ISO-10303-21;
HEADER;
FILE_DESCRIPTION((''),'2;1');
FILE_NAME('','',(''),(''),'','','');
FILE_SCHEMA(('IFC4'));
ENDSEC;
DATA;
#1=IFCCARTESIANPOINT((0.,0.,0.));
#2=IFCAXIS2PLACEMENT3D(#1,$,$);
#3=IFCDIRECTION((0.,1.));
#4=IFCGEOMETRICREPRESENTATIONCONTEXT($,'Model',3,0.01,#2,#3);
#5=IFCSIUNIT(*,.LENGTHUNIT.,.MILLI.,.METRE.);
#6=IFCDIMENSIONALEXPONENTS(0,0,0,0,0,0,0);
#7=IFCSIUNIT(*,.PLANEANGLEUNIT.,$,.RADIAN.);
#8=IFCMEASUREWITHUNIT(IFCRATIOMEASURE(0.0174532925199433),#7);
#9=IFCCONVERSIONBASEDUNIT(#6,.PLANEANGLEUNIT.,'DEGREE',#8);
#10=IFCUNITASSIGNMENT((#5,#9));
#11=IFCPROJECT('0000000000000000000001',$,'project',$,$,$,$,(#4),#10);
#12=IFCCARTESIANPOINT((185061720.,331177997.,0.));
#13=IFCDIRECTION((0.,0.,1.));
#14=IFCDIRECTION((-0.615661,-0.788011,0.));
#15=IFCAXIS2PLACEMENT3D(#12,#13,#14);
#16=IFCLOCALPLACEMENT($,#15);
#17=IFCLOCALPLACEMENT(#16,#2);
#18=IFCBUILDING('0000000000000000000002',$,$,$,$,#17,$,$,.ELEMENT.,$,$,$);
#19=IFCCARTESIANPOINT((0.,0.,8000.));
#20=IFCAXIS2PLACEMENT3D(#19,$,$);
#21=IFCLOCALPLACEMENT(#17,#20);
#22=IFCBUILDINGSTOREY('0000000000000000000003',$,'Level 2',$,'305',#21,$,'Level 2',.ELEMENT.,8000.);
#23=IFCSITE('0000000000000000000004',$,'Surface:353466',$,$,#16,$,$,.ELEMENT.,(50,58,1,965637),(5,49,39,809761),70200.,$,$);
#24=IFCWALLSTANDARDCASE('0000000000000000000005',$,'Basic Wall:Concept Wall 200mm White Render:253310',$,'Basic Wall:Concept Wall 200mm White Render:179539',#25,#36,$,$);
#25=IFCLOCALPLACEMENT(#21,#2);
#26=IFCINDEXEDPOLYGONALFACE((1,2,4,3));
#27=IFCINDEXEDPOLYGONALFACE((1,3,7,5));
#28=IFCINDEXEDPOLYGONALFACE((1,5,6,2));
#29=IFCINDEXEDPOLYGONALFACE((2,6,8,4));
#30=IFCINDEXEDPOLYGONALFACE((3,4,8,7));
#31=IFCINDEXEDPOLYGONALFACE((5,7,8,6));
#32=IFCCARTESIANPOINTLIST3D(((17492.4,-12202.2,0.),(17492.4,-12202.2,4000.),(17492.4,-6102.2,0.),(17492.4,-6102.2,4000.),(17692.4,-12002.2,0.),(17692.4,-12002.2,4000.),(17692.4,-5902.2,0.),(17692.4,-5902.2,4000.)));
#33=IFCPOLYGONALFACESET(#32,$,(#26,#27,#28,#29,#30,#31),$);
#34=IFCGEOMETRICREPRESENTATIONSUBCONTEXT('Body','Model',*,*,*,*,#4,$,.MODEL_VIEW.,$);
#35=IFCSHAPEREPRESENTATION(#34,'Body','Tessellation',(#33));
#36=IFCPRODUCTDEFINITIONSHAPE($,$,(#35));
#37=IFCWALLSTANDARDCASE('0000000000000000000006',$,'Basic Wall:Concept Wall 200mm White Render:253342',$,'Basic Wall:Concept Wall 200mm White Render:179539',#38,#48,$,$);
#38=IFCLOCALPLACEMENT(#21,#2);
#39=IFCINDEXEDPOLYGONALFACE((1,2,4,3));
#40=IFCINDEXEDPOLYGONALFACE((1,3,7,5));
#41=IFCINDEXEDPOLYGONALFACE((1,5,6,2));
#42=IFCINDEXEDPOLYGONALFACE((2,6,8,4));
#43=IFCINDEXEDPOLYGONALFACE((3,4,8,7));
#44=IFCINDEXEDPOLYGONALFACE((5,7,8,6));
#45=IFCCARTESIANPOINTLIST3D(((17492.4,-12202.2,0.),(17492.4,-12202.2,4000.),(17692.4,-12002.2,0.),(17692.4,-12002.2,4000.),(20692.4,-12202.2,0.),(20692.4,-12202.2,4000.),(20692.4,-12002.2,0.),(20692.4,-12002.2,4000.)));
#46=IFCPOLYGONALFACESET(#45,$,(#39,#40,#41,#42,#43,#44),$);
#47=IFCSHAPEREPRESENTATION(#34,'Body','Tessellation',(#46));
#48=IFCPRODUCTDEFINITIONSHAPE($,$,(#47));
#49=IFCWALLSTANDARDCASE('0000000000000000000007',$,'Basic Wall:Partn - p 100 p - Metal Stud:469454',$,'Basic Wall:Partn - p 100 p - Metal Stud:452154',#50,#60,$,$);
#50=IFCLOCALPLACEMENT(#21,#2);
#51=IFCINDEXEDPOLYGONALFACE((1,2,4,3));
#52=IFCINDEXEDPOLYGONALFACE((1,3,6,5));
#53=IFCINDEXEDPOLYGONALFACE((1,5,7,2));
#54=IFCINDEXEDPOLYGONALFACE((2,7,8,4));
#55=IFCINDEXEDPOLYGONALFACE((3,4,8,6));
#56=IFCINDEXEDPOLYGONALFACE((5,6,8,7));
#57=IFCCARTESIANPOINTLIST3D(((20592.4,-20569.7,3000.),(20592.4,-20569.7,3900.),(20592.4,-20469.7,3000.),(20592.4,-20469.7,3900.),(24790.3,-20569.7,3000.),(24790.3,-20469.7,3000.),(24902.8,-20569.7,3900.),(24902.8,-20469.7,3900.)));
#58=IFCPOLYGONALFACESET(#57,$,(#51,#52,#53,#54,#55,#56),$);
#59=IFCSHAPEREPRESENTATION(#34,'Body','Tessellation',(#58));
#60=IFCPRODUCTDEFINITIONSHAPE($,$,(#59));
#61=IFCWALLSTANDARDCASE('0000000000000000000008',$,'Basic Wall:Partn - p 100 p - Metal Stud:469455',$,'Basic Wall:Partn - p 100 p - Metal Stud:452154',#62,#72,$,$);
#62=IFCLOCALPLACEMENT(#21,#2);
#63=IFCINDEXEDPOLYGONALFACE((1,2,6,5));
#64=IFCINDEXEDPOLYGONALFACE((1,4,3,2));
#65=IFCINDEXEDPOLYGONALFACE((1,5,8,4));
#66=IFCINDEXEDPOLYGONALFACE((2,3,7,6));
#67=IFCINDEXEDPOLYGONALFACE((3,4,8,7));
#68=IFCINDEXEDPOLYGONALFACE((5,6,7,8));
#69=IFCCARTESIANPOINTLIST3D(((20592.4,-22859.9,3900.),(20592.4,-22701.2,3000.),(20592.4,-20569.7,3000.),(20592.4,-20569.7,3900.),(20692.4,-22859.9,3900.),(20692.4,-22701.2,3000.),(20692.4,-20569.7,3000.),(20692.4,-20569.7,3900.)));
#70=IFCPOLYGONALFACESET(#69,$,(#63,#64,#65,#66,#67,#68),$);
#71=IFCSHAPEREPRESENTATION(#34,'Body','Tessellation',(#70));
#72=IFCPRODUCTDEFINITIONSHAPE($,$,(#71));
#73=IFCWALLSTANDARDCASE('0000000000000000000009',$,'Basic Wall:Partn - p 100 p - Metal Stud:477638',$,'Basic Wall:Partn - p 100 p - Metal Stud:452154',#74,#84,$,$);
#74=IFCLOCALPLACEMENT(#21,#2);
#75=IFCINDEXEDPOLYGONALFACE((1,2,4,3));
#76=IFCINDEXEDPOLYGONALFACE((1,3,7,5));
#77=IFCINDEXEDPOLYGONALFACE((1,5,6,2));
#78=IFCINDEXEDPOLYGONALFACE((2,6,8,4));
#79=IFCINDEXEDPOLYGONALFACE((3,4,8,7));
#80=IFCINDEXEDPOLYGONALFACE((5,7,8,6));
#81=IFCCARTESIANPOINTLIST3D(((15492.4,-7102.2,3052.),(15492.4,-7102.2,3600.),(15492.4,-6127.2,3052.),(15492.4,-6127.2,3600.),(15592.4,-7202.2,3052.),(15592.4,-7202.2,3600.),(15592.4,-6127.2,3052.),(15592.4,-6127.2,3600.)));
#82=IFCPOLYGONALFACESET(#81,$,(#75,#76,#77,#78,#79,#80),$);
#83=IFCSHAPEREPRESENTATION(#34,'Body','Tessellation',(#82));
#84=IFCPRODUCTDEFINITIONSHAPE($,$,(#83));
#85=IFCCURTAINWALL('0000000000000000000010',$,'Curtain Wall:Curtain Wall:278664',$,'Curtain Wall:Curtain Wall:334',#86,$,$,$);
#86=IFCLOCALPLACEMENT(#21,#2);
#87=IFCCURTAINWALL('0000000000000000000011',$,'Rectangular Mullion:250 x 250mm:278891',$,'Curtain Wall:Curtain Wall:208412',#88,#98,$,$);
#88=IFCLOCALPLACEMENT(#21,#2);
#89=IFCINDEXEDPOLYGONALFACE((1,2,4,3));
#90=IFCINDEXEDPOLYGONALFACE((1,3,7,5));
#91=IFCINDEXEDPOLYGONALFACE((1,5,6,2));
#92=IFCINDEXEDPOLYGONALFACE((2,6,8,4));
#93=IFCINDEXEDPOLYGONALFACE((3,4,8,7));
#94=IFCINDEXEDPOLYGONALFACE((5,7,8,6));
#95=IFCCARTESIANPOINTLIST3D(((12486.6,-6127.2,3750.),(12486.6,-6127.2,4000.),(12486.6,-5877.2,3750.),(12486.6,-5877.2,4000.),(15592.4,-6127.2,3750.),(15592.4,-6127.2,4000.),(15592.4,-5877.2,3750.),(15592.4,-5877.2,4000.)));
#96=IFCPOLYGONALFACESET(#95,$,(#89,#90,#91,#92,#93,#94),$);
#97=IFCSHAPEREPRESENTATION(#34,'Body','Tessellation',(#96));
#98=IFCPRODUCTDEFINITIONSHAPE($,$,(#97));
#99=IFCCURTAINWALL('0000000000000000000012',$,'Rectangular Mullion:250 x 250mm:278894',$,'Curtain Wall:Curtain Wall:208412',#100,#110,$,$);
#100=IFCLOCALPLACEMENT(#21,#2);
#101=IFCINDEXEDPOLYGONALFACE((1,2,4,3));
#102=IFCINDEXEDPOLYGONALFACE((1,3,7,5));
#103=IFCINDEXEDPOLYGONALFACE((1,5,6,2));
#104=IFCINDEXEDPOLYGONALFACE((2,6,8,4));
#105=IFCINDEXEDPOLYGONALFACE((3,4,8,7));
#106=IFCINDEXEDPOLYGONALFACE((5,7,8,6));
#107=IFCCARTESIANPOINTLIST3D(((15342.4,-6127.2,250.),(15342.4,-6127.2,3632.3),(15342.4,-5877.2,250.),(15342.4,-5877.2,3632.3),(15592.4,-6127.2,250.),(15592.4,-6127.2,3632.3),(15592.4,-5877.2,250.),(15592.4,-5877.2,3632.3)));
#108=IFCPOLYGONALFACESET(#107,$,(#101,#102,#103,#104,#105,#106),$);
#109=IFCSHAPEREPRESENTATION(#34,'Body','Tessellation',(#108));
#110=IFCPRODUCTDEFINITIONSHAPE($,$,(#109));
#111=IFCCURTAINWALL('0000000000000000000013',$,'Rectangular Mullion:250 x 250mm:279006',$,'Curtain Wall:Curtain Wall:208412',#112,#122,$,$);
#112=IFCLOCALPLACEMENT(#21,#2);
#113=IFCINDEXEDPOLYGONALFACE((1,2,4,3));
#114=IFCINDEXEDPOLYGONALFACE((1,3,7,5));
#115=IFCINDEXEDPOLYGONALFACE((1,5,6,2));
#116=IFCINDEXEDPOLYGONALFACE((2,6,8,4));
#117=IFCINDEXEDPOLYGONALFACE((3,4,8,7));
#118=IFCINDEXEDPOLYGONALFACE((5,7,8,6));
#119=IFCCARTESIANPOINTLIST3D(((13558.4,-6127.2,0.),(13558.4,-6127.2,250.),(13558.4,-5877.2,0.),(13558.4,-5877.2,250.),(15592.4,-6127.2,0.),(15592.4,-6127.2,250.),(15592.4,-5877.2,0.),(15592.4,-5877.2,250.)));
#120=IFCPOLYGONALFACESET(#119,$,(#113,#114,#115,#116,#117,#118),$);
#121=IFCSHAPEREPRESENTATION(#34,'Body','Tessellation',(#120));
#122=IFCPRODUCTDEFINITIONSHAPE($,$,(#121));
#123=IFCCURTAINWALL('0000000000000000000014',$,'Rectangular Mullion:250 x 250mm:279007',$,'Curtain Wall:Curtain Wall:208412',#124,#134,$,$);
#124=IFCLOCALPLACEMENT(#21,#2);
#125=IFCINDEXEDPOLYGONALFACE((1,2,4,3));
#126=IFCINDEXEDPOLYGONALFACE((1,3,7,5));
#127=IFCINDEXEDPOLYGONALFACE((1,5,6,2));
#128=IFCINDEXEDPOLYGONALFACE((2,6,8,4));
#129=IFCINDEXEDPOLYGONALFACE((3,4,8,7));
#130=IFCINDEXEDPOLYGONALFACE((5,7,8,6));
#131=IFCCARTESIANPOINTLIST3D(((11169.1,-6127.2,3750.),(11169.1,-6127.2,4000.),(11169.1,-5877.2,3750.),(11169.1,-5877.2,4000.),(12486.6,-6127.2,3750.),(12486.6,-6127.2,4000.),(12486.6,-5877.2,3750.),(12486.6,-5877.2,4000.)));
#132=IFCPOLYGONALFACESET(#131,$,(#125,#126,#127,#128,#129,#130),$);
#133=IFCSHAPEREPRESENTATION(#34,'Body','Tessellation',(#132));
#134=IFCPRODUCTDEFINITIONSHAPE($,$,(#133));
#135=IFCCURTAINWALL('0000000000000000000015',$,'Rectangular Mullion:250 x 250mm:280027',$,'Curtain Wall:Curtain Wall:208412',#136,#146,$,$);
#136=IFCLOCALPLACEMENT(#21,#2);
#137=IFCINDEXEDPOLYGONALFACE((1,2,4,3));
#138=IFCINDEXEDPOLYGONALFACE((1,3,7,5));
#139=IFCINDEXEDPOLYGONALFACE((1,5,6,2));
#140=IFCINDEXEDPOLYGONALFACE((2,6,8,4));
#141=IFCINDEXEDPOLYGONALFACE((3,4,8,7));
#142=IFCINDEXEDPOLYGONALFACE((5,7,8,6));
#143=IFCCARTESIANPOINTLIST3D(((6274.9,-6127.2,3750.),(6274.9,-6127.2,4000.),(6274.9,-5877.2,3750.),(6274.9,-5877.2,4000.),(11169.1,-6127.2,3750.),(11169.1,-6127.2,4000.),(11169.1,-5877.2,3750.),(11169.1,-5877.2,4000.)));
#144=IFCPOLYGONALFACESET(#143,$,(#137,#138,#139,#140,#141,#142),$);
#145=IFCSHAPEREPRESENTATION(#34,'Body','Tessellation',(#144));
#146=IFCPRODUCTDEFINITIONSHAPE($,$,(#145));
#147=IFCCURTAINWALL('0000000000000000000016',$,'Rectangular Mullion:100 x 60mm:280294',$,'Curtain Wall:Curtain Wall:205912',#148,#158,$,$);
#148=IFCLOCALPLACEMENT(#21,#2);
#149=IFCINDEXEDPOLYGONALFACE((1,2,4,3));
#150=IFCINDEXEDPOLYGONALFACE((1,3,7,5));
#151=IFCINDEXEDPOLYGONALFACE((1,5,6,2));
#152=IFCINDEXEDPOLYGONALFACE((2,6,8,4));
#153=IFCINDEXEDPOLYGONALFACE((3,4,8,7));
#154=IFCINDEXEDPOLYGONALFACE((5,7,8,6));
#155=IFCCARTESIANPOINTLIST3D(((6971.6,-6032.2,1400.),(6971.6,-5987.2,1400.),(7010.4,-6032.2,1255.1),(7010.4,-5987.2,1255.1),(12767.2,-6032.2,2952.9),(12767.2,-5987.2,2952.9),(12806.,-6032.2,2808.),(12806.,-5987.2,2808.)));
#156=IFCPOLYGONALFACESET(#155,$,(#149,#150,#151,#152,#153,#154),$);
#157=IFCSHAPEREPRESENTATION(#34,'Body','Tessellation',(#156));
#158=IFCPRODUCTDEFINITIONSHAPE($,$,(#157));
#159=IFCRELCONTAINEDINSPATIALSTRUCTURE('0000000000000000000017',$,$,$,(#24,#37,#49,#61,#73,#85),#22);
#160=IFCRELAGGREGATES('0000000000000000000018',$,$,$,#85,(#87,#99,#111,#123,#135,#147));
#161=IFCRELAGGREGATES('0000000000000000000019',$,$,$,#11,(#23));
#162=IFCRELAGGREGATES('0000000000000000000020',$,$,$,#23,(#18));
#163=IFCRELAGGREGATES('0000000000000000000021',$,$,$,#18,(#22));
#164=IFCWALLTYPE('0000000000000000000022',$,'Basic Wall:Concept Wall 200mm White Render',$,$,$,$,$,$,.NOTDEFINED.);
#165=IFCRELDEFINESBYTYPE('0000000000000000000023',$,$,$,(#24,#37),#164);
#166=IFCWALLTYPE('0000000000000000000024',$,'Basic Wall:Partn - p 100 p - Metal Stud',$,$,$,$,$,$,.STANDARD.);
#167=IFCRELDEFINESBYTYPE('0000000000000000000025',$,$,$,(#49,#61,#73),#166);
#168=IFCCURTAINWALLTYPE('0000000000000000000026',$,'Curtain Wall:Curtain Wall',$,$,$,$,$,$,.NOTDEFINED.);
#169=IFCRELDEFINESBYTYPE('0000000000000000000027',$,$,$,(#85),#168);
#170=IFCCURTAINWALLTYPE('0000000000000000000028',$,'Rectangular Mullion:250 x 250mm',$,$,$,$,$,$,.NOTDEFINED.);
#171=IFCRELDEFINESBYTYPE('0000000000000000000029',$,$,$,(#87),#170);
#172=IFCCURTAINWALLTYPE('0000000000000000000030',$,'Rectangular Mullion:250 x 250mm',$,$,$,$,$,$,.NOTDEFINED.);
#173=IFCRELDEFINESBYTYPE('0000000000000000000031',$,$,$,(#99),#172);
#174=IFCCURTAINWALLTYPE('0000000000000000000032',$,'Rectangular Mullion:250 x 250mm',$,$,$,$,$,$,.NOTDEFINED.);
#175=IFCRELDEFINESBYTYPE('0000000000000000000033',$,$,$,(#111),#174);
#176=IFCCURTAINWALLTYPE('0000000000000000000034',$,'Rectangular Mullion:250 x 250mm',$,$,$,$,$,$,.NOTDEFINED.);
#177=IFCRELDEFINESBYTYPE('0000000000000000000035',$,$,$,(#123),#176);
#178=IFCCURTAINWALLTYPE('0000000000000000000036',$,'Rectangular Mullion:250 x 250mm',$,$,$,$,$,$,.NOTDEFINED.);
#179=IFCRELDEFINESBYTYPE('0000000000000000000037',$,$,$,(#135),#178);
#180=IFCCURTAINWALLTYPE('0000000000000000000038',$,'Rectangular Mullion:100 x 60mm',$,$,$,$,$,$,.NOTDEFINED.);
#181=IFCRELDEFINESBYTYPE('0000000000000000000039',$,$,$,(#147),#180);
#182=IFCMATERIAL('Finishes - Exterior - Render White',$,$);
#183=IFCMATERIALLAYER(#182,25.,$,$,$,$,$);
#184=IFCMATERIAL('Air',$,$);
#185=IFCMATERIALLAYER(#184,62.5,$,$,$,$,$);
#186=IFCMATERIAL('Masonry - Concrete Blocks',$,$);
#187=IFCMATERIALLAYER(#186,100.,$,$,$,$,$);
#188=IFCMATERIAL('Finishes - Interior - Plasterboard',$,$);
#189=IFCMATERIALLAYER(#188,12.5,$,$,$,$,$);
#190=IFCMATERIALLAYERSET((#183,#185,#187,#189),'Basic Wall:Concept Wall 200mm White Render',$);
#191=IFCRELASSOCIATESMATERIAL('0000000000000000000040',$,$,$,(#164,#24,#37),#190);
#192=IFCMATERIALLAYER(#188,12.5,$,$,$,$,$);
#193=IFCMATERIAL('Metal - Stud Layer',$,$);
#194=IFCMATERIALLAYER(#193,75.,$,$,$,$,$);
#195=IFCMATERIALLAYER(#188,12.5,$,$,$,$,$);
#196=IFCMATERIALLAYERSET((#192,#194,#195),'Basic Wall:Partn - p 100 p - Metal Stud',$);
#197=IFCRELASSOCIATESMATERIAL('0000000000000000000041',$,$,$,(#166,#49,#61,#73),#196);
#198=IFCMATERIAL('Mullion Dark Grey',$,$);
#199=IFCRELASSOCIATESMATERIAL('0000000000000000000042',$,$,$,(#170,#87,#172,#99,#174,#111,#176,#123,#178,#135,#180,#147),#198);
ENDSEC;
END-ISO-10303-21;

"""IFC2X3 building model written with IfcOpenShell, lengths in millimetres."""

from ifc_helpers import new_model, entity, si_unit, converted_unit, direction, frame, frame_2d, origin, origin_2d_with_axis, place, context, subcontext, project, spatial, polyline, rectangle, outline, extrude, clip, halfspace, source, transform, mapped, material, layer, layer_set, layer_usage, type_object, type_shapes, element, aggregate, save


model = new_model("IFC2X3")

# Units and contexts
model_context = context("Model", 3, precision=0.01, world=origin(), true_north=direction((0.0, 1.0)))
body_context = subcontext(model_context, "Body", "Model", "MODEL_VIEW")
ifc_project = project(units=[si_unit("LENGTHUNIT", "METRE", prefix="MILLI"), converted_unit("PLANEANGLEUNIT", "DEGREE", entity("IfcRatioMeasure", 0.0174532925199433), si_unit("PLANEANGLEUNIT", "RADIAN"), dimensions=[0, 0, 0, 0, 0, 0, 0])], contexts=[model_context])

# Site, building, storey
site_placement = place(None, frame((185061720.0, 331177997.0, 0.0), z_axis=(0.0, 0.0, 1.0), x_axis=(-0.615661, -0.788011, 0.0)))
site = spatial("IfcSite", under=ifc_project, at=site_placement, Name="Surface:353466", CompositionType="ELEMENT", RefLatitude=(50, 58, 1, 965637), RefLongitude=(5, 49, 39, 809761), RefElevation=70200.0)
building_placement = place(site_placement, origin())
building = spatial("IfcBuilding", under=site, at=building_placement, CompositionType="ELEMENT")
storey_placement = place(building_placement, frame((0.0, 0.0, 8000.0)))
storey = spatial("IfcBuildingStorey", under=building, at=storey_placement, Name="Level 2", ObjectType="305", LongName="Level 2", CompositionType="ELEMENT", Elevation=8000.0)

# Walls
ifc_material_1 = material(Name="Finishes - Exterior - Render White")
ifc_layer_1 = layer(ifc_material_1, 25.0)
ifc_material_2 = material(Name="Air")
ifc_layer_2 = layer(ifc_material_2, 62.5)
ifc_material_3 = material(Name="Masonry - Concrete Blocks")
ifc_layer_3 = layer(ifc_material_3, 100.0)
ifc_material_4 = material(Name="Finishes - Interior - Plasterboard")
ifc_layer_4 = layer(ifc_material_4, 12.5)
ifc_layer_set_1 = layer_set([ifc_layer_1, ifc_layer_2, ifc_layer_3, ifc_layer_4], Name="Basic Wall:Concept Wall 200mm White Render")
ifc_layer_usage_1 = layer_usage(ifc_layer_set_1, "AXIS2", "NEGATIVE", 100.0)
wall_type_1 = type_object("IfcWallType", Name="Basic Wall:Concept Wall 200mm White Render", PredefinedType="NOTDEFINED", material=ifc_layer_set_1)
wall_1_placement = place(storey_placement, frame((17592.4, -5902.2, 0.0), z_axis=(0.0, 0.0, 1.0), x_axis=(0.0, -1.0, 0.0)))
element("IfcWallStandardCase", 1, at=wall_1_placement, inside=storey, type_object=wall_type_1, material=ifc_layer_usage_1, Name="Basic Wall:Concept Wall 200mm White Render:253310", ObjectType="Basic Wall:Concept Wall 200mm White Render:179539", context=body_context, shape_type="Clipping", body=[
    clip(extrude(outline(polyline([(6300.0, -100.0), (6100.0, 100.0), (0.0, 100.0), (200.0, -100.0), (6300.0, -100.0)])), origin(), (0.0, 0.0, 1.0), 4000.0), halfspace(frame((0.0, 0.0, -8000.0)), True)),
])
ifc_layer_usage_2 = layer_usage(ifc_layer_set_1, "AXIS2", "NEGATIVE", 100.0)
wall_2_placement = place(storey_placement, frame((17492.4, -12102.2, 0.0)))
element("IfcWallStandardCase", 2, at=wall_2_placement, inside=storey, type_object=wall_type_1, material=ifc_layer_usage_2, Name="Basic Wall:Concept Wall 200mm White Render:253342", ObjectType="Basic Wall:Concept Wall 200mm White Render:179539", context=body_context, shape_type="Clipping", body=[
    clip(extrude(outline(polyline([(0.0, -100.0), (3200.0, -100.0), (3200.0, 100.0), (200.0, 100.0), (0.0, -100.0)])), origin(), (0.0, 0.0, 1.0), 4000.0), halfspace(frame((0.0, 0.0, -8000.0)), True)),
])
ifc_layer_5 = layer(ifc_material_4, 12.5)
ifc_material_5 = material(Name="Metal - Stud Layer")
ifc_layer_6 = layer(ifc_material_5, 75.0)
ifc_layer_7 = layer(ifc_material_4, 12.5)
ifc_layer_set_2 = layer_set([ifc_layer_5, ifc_layer_6, ifc_layer_7], Name="Basic Wall:Partn - p 100 p - Metal Stud")
ifc_layer_usage_3 = layer_usage(ifc_layer_set_2, "AXIS2", "POSITIVE", -50.0)
wall_type_2 = type_object("IfcWallType", Name="Basic Wall:Partn - p 100 p - Metal Stud", PredefinedType="STANDARD", material=ifc_layer_set_2)
wall_3_placement = place(storey_placement, frame((24902.8, -20519.7, 3000.0), z_axis=(0.0, 0.0, 1.0), x_axis=(-1.0, 0.0, 0.0)))
element("IfcWallStandardCase", 3, at=wall_3_placement, inside=storey, type_object=wall_type_2, material=ifc_layer_usage_3, Name="Basic Wall:Partn - p 100 p - Metal Stud:469454", ObjectType="Basic Wall:Partn - p 100 p - Metal Stud:452154", context=body_context, shape_type="Clipping", body=[
    clip(extrude(rectangle(XDim=4310.4, YDim=100.0, at=frame_2d((2155.2, 0.0), x_axis=(-1.0, 0.0))), origin(), (0.0, 0.0, 1.0), 900.0), halfspace(frame((112.5, -50.0, 0.0), z_axis=(-0.992278, 0.0, -0.124035), x_axis=(0.0, 1.0, 0.0)), False)),
])
ifc_layer_usage_4 = layer_usage(ifc_layer_set_2, "AXIS2", "POSITIVE", -50.0)
wall_4_placement = place(storey_placement, frame((20642.4, -20569.7, 3000.0), z_axis=(0.0, 0.0, 1.0), x_axis=(0.0, -1.0, 0.0)))
element("IfcWallStandardCase", 4, at=wall_4_placement, inside=storey, type_object=wall_type_2, material=ifc_layer_usage_4, Name="Basic Wall:Partn - p 100 p - Metal Stud:469455", ObjectType="Basic Wall:Partn - p 100 p - Metal Stud:452154", context=body_context, shape_type="Clipping", body=[
    clip(extrude(rectangle(XDim=2290.2, YDim=100.0, at=frame_2d((1145.1, 0.0), x_axis=(-1.0, 0.0))), origin(), (0.0, 0.0, 1.0), 900.0), halfspace(frame((2290.2, -50.0, 900.0), z_axis=(0.984808, 0.0, -0.173648), x_axis=(0.0, 1.0, 0.0)), False)),
])
ifc_layer_usage_5 = layer_usage(ifc_layer_set_2, "AXIS2", "POSITIVE", -50.0)
wall_5_placement = place(storey_placement, frame((15542.4, -6127.2, 3052.0), z_axis=(0.0, 0.0, 1.0), x_axis=(0.0, -1.0, 0.0)))
element("IfcWallStandardCase", 5, at=wall_5_placement, inside=storey, type_object=wall_type_2, material=ifc_layer_usage_5, Name="Basic Wall:Partn - p 100 p - Metal Stud:477638", ObjectType="Basic Wall:Partn - p 100 p - Metal Stud:452154", context=body_context, shape_type="SweptSolid", body=[
    extrude(outline(polyline([(975.0, -50.0), (1075.0, 50.0), (0.0, 50.0), (0.0, -50.0), (975.0, -50.0)])), origin(), (0.0, 0.0, 1.0), 548.0),
])

# Curtain walls
curtain_wall_type_1 = type_object("IfcCurtainWallType", Name="Curtain Wall:Curtain Wall", PredefinedType="NOTDEFINED")
curtain_wall_1_placement = place(storey_placement, frame((0.0, 0.0, -8000.0)))
curtain_wall_1 = element("IfcCurtainWall", 6, at=curtain_wall_1_placement, inside=storey, type_object=curtain_wall_type_1, Name="Curtain Wall:Curtain Wall:278664", ObjectType="Curtain Wall:Curtain Wall:334")
ifc_material_6 = material(Name="Mullion Dark Grey")
curtain_wall_type_2 = type_object("IfcCurtainWallType", Name="Rectangular Mullion:250 x 250mm", PredefinedType="NOTDEFINED", material=ifc_material_6)
shared_shape_1 = source(origin(), body_context, "Body", "SweptSolid", [
    extrude(rectangle(XDim=250.0, YDim=250.0, at=origin_2d_with_axis()), frame((-125.0, 0.0, -3105.8), z_axis=(0.0, 0.0, 1.0), x_axis=(-1.0, 0.0, 0.0)), (0.0, 0.0, 1.0), 3105.8),
])
type_shapes(curtain_wall_type_2, [shared_shape_1])
curtain_wall_2_placement = place(storey_placement, frame((15592.4, -6002.2, 4000.0), z_axis=(1.0, 0.0, 0.0), x_axis=(0.0, 0.0, 1.0)))
curtain_wall_2 = element("IfcCurtainWall", 7, at=curtain_wall_2_placement, type_object=curtain_wall_type_2, material=ifc_material_6, Name="Rectangular Mullion:250 x 250mm:278891", ObjectType="Curtain Wall:Curtain Wall:208412", context=body_context, shape_type="MappedRepresentation", body=[
    mapped(shared_shape_1, transform((0.0, 0.0, 0.0), scale=1.0)),
])
curtain_wall_type_3 = type_object("IfcCurtainWallType", Name="Rectangular Mullion:250 x 250mm", PredefinedType="NOTDEFINED", material=ifc_material_6)
shared_shape_2 = source(origin(), body_context, "Body", "SweptSolid", [
    extrude(rectangle(XDim=250.0, YDim=250.0, at=origin_2d_with_axis()), frame((-125.0, 0.0, -3382.3), z_axis=(0.0, 0.0, 1.0), x_axis=(-1.0, 0.0, 0.0)), (0.0, 0.0, 1.0), 3382.3),
])
type_shapes(curtain_wall_type_3, [shared_shape_2])
curtain_wall_3_placement = place(storey_placement, frame((15592.4, -6002.2, 250.0), z_axis=(0.0, 0.0, -1.0), x_axis=(1.0, 0.0, 0.0)))
curtain_wall_3 = element("IfcCurtainWall", 8, at=curtain_wall_3_placement, type_object=curtain_wall_type_3, material=ifc_material_6, Name="Rectangular Mullion:250 x 250mm:278894", ObjectType="Curtain Wall:Curtain Wall:208412", context=body_context, shape_type="MappedRepresentation", body=[
    mapped(shared_shape_2, transform((0.0, 0.0, 0.0), scale=1.0)),
])
curtain_wall_type_4 = type_object("IfcCurtainWallType", Name="Rectangular Mullion:250 x 250mm", PredefinedType="NOTDEFINED", material=ifc_material_6)
shared_shape_3 = source(origin(), body_context, "Body", "SweptSolid", [
    extrude(rectangle(XDim=250.0, YDim=250.0, at=origin_2d_with_axis()), frame((-125.0, 0.0, -2034.0), z_axis=(0.0, 0.0, 1.0), x_axis=(-1.0, 0.0, 0.0)), (0.0, 0.0, 1.0), 2034.0),
])
type_shapes(curtain_wall_type_4, [shared_shape_3])
curtain_wall_4_placement = place(storey_placement, frame((13558.4, -6002.2, 0.0), z_axis=(-1.0, 0.0, 0.0), x_axis=(0.0, 0.0, -1.0)))
curtain_wall_4 = element("IfcCurtainWall", 9, at=curtain_wall_4_placement, type_object=curtain_wall_type_4, material=ifc_material_6, Name="Rectangular Mullion:250 x 250mm:279006", ObjectType="Curtain Wall:Curtain Wall:208412", context=body_context, shape_type="MappedRepresentation", body=[
    mapped(shared_shape_3, transform((0.0, 0.0, 0.0), scale=1.0)),
])
curtain_wall_type_5 = type_object("IfcCurtainWallType", Name="Rectangular Mullion:250 x 250mm", PredefinedType="NOTDEFINED", material=ifc_material_6)
shared_shape_4 = source(origin(), body_context, "Body", "SweptSolid", [
    extrude(rectangle(XDim=250.0, YDim=250.0, at=origin_2d_with_axis()), frame((-125.0, 0.0, -1317.5), z_axis=(0.0, 0.0, 1.0), x_axis=(-1.0, 0.0, 0.0)), (0.0, 0.0, 1.0), 1317.5),
])
type_shapes(curtain_wall_type_5, [shared_shape_4])
curtain_wall_5_placement = place(storey_placement, frame((12486.6, -6002.2, 4000.0), z_axis=(1.0, 0.0, 0.0), x_axis=(0.0, 0.0, 1.0)))
curtain_wall_5 = element("IfcCurtainWall", 10, at=curtain_wall_5_placement, type_object=curtain_wall_type_5, material=ifc_material_6, Name="Rectangular Mullion:250 x 250mm:279007", ObjectType="Curtain Wall:Curtain Wall:208412", context=body_context, shape_type="MappedRepresentation", body=[
    mapped(shared_shape_4, transform((0.0, 0.0, 0.0), scale=1.0)),
])
curtain_wall_type_6 = type_object("IfcCurtainWallType", Name="Rectangular Mullion:250 x 250mm", PredefinedType="NOTDEFINED", material=ifc_material_6)
shared_shape_5 = source(origin(), body_context, "Body", "SweptSolid", [
    extrude(rectangle(XDim=250.0, YDim=250.0, at=origin_2d_with_axis()), frame((-125.0, 0.0, -4894.2), z_axis=(0.0, 0.0, 1.0), x_axis=(-1.0, 0.0, 0.0)), (0.0, 0.0, 1.0), 4894.2),
])
type_shapes(curtain_wall_type_6, [shared_shape_5])
curtain_wall_6_placement = place(storey_placement, frame((11169.1, -6002.2, 4000.0), z_axis=(1.0, 0.0, 0.0), x_axis=(0.0, 0.0, 1.0)))
curtain_wall_6 = element("IfcCurtainWall", 11, at=curtain_wall_6_placement, type_object=curtain_wall_type_6, material=ifc_material_6, Name="Rectangular Mullion:250 x 250mm:280027", ObjectType="Curtain Wall:Curtain Wall:208412", context=body_context, shape_type="MappedRepresentation", body=[
    mapped(shared_shape_5, transform((0.0, 0.0, 0.0), scale=1.0)),
])
curtain_wall_type_7 = type_object("IfcCurtainWallType", Name="Rectangular Mullion:100 x 60mm", PredefinedType="NOTDEFINED", material=ifc_material_6)
shared_shape_6 = source(origin(), body_context, "Body", "SweptSolid", [
    extrude(rectangle(XDim=45.0, YDim=150.0, at=frame_2d((0.0, 0.0), x_axis=(1.0, 0.0))), frame((0.0, 7.5, -6000.0), z_axis=(0.0, 0.0, 1.0), x_axis=(0.0, -1.0, 0.0)), (0.0, 0.0, 1.0), 6000.0),
])
type_shapes(curtain_wall_type_7, [shared_shape_6])
curtain_wall_7_placement = place(storey_placement, frame((12786.6, -6002.2, 2880.5), z_axis=(0.965926, 0.0, 0.258819), x_axis=(-0.258819, 0.0, 0.965926)))
curtain_wall_7 = element("IfcCurtainWall", 12, at=curtain_wall_7_placement, type_object=curtain_wall_type_7, material=ifc_material_6, Name="Rectangular Mullion:100 x 60mm:280294", ObjectType="Curtain Wall:Curtain Wall:205912", context=body_context, shape_type="MappedRepresentation", body=[
    mapped(shared_shape_6, transform((0.0, 0.0, 0.0), scale=1.0)),
])
aggregate(curtain_wall_1, [curtain_wall_2, curtain_wall_3, curtain_wall_4, curtain_wall_5, curtain_wall_6, curtain_wall_7])

save(model, "model.ifc")
